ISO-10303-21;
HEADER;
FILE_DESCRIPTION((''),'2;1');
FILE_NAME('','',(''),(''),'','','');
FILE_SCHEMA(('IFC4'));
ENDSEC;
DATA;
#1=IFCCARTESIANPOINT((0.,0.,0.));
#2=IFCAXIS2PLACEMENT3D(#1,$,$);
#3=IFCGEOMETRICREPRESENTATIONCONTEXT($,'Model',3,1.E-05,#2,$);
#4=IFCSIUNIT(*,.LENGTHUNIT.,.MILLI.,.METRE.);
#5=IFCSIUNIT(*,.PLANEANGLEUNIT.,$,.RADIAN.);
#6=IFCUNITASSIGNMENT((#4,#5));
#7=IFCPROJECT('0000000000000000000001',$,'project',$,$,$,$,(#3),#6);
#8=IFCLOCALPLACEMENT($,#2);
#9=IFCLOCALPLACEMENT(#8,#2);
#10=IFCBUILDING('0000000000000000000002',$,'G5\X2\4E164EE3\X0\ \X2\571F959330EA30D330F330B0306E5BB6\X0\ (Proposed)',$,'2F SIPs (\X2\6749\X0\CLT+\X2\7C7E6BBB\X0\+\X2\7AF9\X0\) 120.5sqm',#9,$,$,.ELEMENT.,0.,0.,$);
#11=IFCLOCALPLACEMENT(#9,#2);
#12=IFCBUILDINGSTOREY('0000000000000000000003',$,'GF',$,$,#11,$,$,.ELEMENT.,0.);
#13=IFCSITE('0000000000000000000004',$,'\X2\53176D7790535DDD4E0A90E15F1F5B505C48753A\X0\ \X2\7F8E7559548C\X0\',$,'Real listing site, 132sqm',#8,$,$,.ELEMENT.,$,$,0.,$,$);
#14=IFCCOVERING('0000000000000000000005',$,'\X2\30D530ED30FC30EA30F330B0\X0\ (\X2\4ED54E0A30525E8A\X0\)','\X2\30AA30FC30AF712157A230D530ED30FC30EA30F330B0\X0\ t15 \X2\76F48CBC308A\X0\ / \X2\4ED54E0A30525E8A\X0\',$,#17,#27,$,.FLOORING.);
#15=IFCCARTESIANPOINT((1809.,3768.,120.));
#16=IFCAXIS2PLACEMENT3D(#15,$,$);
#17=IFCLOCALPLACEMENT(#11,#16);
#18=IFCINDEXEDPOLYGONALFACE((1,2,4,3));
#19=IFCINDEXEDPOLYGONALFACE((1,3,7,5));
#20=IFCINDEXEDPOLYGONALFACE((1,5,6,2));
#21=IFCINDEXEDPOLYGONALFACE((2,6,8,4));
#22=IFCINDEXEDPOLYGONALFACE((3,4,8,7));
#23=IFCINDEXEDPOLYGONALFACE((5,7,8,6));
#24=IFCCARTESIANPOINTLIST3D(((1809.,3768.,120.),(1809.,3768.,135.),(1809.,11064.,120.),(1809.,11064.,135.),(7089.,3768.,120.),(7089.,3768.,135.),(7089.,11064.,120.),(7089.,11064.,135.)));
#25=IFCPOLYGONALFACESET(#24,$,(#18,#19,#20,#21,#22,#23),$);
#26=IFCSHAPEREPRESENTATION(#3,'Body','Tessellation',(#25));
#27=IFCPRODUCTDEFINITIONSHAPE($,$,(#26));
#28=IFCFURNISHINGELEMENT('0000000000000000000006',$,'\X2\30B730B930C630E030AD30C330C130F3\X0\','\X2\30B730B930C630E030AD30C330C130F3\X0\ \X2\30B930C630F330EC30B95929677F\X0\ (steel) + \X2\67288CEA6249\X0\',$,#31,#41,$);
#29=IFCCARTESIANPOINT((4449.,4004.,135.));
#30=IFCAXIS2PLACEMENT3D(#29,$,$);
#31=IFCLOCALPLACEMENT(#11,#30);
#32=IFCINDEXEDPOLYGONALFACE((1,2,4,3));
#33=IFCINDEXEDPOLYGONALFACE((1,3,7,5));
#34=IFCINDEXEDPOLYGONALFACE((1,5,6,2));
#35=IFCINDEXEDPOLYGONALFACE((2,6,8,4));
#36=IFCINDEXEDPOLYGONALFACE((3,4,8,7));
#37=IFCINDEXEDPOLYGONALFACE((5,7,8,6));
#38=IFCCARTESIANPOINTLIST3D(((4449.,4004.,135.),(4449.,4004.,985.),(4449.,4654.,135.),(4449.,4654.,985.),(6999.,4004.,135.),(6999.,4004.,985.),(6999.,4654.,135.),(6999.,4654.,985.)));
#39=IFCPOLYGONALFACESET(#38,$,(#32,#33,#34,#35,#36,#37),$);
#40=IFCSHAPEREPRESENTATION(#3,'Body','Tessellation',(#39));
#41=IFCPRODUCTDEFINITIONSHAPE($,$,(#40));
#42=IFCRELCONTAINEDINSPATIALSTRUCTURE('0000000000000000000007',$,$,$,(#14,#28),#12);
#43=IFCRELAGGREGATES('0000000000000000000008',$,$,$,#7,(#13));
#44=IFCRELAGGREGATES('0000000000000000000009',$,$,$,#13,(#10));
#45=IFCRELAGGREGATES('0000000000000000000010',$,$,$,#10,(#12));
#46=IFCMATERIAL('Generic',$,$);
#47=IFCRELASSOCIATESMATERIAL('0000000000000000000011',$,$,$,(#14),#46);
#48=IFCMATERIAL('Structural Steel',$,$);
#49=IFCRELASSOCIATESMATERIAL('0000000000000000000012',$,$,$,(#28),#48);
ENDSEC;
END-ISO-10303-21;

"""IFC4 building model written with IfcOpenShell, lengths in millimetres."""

from ifc_helpers import new_model, si_unit, frame, frame_2d, origin, place, context, project, spatial, rectangle, extrude, material, element, save


model = new_model("IFC4")

# Units and contexts
model_context = context("Model", 3, precision=1e-05, world=origin())
ifc_project = project(units=[si_unit("LENGTHUNIT", "METRE", prefix="MILLI"), si_unit("PLANEANGLEUNIT", "RADIAN")], contexts=[model_context])

# Site, building, storey
site_placement = place(None, origin())
site = spatial("IfcSite", under=ifc_project, at=site_placement, Name="北海道川上郡弟子屈町 美留和", ObjectType="Real listing site, 132sqm", CompositionType="ELEMENT", RefElevation=0.0)
building_placement = place(site_placement, origin())
building = spatial("IfcBuilding", under=site, at=building_placement, Name="G5世代 土間リビングの家 (Proposed)", ObjectType="2F SIPs (杉CLT+籾殻+竹) 120.5sqm", CompositionType="ELEMENT", ElevationOfRefHeight=0.0, ElevationOfTerrain=0.0)
storey_placement = place(building_placement, origin())
storey = spatial("IfcBuildingStorey", under=building, at=storey_placement, Name="GF", CompositionType="ELEMENT", Elevation=0.0)

# Shared definitions
ifc_material_1 = material(Name="Generic")

# Covering
covering_placement = place(storey_placement, frame((1809.0, 3768.0, 120.0)))
element("IfcCovering", 1, at=covering_placement, inside=storey, material=ifc_material_1, Name="フローリング (仕上げ床)", Description="オーク無垢フローリング t15 直貼り / 仕上げ床", PredefinedType="FLOORING", context=model_context, shape_type="SweptSolid", body=[
    extrude(rectangle(XDim=5280.0, YDim=7296.0, at=frame_2d((2640.0, 3648.0))), frame((1809.0, 3768.0, 120.0)), (0.0, 0.0, 1.0), 15.0),
])

# Furnishing element
ifc_material_2 = material(Name="Structural Steel")
furnishing_placement = place(storey_placement, frame((4449.0, 4004.0, 135.0)))
element("IfcFurnishingElement", 2, at=furnishing_placement, inside=storey, material=ifc_material_2, Name="システムキッチン", Description="システムキッチン ステンレス天板 (steel) + 木質扉", context=model_context, shape_type="SweptSolid", body=[
    extrude(rectangle(XDim=2550.0, YDim=650.0, at=frame_2d((1275.0, 325.0))), frame((4449.0, 4004.0, 135.0)), (0.0, 0.0, 1.0), 850.0),
])

save(model, "model.ifc")
